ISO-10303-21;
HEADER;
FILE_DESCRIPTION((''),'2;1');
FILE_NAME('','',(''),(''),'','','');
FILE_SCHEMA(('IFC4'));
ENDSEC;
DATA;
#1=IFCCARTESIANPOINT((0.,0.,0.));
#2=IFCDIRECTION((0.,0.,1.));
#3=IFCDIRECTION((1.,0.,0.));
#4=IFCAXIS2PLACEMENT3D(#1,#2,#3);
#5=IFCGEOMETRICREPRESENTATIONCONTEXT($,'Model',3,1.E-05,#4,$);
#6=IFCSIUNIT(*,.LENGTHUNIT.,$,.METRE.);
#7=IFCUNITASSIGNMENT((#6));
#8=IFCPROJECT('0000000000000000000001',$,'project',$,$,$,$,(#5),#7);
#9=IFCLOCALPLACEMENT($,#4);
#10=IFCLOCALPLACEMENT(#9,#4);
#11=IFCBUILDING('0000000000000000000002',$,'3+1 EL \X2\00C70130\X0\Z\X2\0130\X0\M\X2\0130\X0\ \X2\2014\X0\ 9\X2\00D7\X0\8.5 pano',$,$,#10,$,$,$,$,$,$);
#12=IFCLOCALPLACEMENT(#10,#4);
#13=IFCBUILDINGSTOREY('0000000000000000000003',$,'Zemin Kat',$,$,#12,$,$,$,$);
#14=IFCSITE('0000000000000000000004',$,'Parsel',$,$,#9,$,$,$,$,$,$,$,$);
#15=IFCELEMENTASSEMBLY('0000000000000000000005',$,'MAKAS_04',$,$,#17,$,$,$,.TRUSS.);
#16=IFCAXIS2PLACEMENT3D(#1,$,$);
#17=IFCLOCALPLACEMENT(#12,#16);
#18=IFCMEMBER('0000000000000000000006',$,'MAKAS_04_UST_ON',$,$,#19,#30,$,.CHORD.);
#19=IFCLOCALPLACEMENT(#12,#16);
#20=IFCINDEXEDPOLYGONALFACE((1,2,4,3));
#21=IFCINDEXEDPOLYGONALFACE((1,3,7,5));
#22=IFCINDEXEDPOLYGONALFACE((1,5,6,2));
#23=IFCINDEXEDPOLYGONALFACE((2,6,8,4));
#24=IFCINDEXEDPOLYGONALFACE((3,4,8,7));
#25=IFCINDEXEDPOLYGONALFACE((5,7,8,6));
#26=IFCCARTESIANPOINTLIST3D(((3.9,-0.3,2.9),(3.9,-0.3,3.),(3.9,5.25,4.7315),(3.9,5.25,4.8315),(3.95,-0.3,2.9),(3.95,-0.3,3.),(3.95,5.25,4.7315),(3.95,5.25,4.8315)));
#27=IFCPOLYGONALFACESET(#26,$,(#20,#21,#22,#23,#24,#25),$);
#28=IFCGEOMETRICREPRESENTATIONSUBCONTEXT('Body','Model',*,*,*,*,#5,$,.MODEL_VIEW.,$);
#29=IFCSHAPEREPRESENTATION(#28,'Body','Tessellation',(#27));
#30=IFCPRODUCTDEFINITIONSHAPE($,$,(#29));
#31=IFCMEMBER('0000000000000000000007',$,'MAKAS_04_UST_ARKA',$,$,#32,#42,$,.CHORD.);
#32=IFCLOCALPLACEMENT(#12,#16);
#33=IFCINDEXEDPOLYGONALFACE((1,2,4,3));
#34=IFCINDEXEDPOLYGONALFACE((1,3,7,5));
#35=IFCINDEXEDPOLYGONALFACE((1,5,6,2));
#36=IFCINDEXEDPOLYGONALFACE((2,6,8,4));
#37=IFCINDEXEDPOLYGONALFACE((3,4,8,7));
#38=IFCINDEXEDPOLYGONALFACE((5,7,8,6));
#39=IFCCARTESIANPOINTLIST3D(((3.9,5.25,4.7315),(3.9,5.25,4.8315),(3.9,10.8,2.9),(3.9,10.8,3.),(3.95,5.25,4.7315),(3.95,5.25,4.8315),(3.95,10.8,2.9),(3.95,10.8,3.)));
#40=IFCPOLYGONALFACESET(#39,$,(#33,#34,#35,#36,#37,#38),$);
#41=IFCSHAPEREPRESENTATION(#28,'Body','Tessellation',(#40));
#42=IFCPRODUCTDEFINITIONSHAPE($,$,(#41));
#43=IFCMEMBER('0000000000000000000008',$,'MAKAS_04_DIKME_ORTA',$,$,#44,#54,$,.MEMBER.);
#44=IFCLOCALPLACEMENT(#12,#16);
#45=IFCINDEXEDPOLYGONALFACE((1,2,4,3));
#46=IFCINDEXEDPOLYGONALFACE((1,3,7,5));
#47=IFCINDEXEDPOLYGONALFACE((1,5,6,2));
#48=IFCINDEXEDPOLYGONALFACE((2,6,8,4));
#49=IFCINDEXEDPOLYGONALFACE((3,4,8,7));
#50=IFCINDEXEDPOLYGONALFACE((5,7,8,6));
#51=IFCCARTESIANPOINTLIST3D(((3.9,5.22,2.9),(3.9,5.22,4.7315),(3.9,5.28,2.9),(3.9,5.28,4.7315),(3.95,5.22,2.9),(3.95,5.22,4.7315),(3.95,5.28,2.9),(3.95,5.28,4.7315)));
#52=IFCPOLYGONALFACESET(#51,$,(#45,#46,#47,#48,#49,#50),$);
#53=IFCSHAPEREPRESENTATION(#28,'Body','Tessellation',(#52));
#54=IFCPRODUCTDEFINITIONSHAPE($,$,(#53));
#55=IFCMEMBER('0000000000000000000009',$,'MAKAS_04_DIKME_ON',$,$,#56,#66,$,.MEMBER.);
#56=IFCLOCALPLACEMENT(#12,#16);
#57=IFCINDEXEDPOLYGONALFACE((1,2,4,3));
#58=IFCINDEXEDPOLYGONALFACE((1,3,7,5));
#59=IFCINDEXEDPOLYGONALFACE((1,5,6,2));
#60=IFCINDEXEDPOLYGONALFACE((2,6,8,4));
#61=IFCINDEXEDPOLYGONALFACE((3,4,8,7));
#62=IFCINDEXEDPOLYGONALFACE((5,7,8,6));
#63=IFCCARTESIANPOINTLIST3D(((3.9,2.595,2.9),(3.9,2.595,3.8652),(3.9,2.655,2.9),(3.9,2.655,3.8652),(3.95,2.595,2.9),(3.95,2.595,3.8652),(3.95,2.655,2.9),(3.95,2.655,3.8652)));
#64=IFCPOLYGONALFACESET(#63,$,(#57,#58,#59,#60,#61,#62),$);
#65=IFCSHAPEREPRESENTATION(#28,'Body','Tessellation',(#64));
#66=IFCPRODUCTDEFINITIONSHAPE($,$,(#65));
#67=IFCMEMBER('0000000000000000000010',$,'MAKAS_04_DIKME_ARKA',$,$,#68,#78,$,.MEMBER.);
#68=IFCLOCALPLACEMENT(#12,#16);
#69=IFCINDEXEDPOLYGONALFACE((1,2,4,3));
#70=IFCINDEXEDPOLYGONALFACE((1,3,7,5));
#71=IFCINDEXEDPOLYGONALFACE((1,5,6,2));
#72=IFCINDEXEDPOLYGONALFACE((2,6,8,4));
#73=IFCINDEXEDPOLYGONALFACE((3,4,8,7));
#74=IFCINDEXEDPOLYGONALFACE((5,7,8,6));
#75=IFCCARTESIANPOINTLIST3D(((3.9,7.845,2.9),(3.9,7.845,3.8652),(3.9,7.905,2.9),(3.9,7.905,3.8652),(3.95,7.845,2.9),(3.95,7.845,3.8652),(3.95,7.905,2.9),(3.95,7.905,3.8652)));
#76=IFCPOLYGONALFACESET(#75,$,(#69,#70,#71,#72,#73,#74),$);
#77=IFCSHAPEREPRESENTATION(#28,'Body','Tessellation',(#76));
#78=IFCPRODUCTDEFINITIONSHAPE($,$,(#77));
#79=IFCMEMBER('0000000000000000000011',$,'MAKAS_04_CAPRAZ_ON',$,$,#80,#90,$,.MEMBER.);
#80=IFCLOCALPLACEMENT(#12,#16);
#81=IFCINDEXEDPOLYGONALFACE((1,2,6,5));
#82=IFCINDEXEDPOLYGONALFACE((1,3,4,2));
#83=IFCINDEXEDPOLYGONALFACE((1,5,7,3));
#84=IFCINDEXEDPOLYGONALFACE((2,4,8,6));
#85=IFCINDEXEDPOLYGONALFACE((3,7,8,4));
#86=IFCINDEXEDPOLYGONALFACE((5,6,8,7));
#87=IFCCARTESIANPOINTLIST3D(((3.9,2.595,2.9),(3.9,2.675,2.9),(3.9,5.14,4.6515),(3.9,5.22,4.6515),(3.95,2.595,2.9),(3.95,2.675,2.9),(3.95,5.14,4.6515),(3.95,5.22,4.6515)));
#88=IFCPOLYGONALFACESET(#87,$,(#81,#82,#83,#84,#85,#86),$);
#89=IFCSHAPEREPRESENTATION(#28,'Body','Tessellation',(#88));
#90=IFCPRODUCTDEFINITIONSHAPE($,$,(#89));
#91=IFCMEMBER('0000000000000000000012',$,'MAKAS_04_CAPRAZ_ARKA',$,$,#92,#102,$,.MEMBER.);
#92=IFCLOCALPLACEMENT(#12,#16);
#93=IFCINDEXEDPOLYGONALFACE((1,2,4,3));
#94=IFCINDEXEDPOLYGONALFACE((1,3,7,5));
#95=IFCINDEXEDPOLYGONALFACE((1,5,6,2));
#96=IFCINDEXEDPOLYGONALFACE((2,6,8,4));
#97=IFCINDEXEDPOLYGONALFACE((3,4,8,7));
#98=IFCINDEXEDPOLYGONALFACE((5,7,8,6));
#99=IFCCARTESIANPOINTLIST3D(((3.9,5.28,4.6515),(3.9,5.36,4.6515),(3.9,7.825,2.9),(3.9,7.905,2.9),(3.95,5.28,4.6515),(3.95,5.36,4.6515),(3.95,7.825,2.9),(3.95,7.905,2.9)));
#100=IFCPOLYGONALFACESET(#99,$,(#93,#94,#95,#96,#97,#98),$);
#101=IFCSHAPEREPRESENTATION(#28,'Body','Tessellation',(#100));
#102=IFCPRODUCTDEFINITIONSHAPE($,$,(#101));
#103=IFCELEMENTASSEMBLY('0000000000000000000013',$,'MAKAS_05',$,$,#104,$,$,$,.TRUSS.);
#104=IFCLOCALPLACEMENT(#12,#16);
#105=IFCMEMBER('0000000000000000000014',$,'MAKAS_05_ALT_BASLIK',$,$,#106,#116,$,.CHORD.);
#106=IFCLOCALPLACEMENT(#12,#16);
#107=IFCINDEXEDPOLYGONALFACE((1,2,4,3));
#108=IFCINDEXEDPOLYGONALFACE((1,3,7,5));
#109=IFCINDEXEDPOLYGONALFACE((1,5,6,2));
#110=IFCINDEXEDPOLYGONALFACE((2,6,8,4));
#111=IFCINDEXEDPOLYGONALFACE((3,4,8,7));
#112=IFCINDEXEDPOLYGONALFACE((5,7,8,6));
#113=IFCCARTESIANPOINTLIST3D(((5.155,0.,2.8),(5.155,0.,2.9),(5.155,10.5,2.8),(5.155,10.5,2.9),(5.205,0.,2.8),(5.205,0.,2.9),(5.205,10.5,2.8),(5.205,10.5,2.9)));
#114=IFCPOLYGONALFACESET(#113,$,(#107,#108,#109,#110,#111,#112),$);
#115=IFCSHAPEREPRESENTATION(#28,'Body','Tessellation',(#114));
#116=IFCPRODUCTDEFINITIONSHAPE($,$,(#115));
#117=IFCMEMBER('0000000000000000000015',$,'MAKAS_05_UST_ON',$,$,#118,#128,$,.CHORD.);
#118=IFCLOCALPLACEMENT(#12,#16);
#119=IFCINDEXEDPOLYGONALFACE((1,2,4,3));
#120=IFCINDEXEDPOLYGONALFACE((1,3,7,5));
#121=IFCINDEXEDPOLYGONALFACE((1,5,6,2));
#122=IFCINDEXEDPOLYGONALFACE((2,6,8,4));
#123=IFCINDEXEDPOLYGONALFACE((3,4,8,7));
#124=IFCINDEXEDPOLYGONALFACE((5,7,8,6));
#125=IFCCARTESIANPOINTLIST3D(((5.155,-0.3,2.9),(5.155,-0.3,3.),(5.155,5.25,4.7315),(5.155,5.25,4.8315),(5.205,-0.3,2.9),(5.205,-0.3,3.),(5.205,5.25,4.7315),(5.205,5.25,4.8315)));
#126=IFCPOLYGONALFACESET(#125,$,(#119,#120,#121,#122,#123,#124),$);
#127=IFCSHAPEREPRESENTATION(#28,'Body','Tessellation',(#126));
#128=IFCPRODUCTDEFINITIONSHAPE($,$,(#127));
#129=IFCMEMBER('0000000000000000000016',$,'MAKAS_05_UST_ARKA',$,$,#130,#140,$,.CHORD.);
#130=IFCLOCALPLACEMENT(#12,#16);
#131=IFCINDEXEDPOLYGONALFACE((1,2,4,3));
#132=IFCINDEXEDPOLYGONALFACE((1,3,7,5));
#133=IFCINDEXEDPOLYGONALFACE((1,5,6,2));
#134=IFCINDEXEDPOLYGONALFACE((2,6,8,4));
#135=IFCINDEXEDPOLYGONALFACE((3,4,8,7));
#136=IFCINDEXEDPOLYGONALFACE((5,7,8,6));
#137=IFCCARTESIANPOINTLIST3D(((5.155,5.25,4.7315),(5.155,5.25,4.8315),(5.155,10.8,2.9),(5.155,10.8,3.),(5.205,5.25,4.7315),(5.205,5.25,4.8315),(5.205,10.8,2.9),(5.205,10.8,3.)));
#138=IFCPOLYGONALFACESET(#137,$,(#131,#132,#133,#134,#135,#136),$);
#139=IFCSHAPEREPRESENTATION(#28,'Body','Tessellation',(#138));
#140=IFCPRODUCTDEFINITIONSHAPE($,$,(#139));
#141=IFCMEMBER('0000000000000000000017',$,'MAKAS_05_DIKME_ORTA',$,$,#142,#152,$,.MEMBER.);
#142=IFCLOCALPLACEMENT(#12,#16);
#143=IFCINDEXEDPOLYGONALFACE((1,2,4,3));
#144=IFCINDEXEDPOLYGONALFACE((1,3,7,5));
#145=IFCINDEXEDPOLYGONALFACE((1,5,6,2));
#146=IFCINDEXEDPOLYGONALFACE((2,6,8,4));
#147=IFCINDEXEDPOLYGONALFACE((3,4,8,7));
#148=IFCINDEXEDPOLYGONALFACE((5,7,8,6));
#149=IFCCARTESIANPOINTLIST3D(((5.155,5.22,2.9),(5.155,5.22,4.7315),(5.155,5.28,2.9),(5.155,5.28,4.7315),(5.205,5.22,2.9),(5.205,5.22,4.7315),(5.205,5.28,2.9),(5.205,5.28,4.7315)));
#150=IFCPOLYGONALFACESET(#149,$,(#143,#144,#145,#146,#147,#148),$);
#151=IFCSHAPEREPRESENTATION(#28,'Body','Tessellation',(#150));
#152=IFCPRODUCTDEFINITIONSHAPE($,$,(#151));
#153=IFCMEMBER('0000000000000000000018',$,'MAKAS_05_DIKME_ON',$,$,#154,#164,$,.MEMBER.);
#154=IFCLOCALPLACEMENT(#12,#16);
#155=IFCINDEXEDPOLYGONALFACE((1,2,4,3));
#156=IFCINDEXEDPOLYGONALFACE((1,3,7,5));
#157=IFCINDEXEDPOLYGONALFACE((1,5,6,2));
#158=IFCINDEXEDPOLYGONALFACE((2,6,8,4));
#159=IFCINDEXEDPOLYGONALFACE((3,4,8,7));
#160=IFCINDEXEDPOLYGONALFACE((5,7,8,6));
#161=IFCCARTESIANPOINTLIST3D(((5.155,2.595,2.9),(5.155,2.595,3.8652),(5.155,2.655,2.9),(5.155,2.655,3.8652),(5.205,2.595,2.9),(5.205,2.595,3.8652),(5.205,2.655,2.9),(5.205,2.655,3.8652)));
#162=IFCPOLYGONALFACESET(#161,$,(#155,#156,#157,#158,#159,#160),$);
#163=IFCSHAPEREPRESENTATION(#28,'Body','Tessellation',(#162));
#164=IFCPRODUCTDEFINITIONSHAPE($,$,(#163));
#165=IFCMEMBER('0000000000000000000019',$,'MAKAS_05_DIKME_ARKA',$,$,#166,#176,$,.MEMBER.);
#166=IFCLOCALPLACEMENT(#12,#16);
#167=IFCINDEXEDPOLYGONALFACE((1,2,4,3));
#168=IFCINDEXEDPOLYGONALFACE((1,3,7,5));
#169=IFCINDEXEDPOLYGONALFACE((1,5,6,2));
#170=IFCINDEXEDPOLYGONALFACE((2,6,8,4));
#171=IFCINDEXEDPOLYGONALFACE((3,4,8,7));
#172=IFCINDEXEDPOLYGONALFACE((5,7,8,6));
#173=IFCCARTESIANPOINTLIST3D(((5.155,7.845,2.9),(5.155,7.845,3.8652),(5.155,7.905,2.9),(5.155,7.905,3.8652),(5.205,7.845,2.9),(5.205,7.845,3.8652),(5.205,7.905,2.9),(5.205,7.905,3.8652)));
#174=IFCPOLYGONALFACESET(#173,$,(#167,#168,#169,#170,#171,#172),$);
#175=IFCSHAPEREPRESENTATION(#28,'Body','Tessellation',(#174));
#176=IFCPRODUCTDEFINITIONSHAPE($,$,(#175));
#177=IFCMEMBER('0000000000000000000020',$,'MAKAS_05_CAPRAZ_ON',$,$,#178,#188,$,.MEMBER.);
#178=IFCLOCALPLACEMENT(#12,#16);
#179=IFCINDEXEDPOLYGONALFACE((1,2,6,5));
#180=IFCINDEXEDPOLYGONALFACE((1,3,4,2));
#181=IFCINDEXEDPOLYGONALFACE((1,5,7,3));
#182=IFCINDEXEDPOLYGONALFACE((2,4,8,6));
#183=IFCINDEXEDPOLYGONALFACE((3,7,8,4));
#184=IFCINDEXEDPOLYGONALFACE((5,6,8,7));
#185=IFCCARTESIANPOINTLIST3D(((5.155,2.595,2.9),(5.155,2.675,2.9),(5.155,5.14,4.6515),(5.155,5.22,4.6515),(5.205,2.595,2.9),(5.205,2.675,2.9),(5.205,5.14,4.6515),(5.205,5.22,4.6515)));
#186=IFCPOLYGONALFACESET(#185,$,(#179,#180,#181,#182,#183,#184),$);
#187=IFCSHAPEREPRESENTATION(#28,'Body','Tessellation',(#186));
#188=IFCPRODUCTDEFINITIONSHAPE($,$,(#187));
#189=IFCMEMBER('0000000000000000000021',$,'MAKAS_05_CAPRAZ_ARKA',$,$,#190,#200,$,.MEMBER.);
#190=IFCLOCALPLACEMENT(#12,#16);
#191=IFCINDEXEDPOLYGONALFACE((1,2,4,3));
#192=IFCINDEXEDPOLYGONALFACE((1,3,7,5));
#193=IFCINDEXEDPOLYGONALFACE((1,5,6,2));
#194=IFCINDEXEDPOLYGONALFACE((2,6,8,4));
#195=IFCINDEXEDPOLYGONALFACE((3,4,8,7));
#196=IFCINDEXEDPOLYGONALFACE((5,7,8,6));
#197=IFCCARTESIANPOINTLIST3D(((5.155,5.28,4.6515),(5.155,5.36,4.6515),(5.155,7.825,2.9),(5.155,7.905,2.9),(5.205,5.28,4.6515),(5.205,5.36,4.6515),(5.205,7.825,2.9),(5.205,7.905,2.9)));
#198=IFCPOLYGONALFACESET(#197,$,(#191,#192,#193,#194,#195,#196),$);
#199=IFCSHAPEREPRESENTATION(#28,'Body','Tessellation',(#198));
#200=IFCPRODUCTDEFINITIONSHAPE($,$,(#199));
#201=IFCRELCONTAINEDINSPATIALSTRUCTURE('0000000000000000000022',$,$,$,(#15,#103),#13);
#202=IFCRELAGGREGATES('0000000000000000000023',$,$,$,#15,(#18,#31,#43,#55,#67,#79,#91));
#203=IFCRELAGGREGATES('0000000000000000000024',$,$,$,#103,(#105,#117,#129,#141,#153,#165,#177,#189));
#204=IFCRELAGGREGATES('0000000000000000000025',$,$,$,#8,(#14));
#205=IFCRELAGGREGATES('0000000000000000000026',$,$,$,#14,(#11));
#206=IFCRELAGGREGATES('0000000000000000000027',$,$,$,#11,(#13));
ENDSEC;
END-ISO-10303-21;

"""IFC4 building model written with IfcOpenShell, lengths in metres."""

from ifc_helpers import new_model, si_unit, frame, origin_with_axes, place, context, subcontext, project, spatial, line, indexed_curve, outline, extrude, element, aggregate, save


model = new_model("IFC4")

# Units and contexts
model_context = context("Model", 3, precision=1e-05, world=origin_with_axes())
body_context = subcontext(model_context, "Body", "Model", "MODEL_VIEW")
ifc_project = project(units=[si_unit("LENGTHUNIT", "METRE")], contexts=[model_context])

# Site, building, storey
site_placement = place(None, origin_with_axes())
site = spatial("IfcSite", under=ifc_project, at=site_placement, Name="Parsel")
building_placement = place(site_placement, origin_with_axes())
building = spatial("IfcBuilding", under=site, at=building_placement, Name="3+1 EL ÇİZİMİ — 9×8.5 pano")
storey_placement = place(building_placement, origin_with_axes())
storey = spatial("IfcBuildingStorey", under=building, at=storey_placement, Name="Zemin Kat")

# Element assemblies, members
assembly_1_placement = place(storey_placement, origin_with_axes())
assembly_1 = element("IfcElementAssembly", 1, at=assembly_1_placement, inside=storey, Name="MAKAS_04", PredefinedType="TRUSS")
member_1_placement = place(assembly_1_placement, origin_with_axes())
member_1 = element("IfcMember", 2, at=member_1_placement, Name="MAKAS_04_UST_ON", PredefinedType="CHORD", context=body_context, shape_type="SweptSolid", body=[
    extrude(outline(indexed_curve([(-0.3, 2.9), (5.25, 4.7315), (5.25, 4.8315), (-0.3, 3.0)], segments=[line(1, 2, 3, 4, 1)])), frame((3.9, 0.0, 0.0), z_axis=(1.0, 0.0, 0.0), x_axis=(0.0, 1.0, 0.0)), (0.0, 0.0, 1.0), 0.05),
])
member_2_placement = place(assembly_1_placement, origin_with_axes())
member_2 = element("IfcMember", 3, at=member_2_placement, Name="MAKAS_04_UST_ARKA", PredefinedType="CHORD", context=body_context, shape_type="SweptSolid", body=[
    extrude(outline(indexed_curve([(5.25, 4.7315), (10.8, 2.9), (10.8, 3.0), (5.25, 4.8315)], segments=[line(1, 2, 3, 4, 1)])), frame((3.9, 0.0, 0.0), z_axis=(1.0, 0.0, 0.0), x_axis=(0.0, 1.0, 0.0)), (0.0, 0.0, 1.0), 0.05),
])
member_3_placement = place(assembly_1_placement, origin_with_axes())
member_3 = element("IfcMember", 4, at=member_3_placement, Name="MAKAS_04_DIKME_ORTA", PredefinedType="MEMBER", context=body_context, shape_type="SweptSolid", body=[
    extrude(outline(indexed_curve([(5.22, 2.9), (5.28, 2.9), (5.28, 4.7315), (5.22, 4.7315)], segments=[line(1, 2, 3, 4, 1)])), frame((3.9, 0.0, 0.0), z_axis=(1.0, 0.0, 0.0), x_axis=(0.0, 1.0, 0.0)), (0.0, 0.0, 1.0), 0.05),
])
member_4_placement = place(assembly_1_placement, origin_with_axes())
member_4 = element("IfcMember", 5, at=member_4_placement, Name="MAKAS_04_DIKME_ON", PredefinedType="MEMBER", context=body_context, shape_type="SweptSolid", body=[
    extrude(outline(indexed_curve([(2.595, 2.9), (2.655, 2.9), (2.655, 3.8653), (2.595, 3.8653)], segments=[line(1, 2, 3, 4, 1)])), frame((3.9, 0.0, 0.0), z_axis=(1.0, 0.0, 0.0), x_axis=(0.0, 1.0, 0.0)), (0.0, 0.0, 1.0), 0.05),
])
member_5_placement = place(assembly_1_placement, origin_with_axes())
member_5 = element("IfcMember", 6, at=member_5_placement, Name="MAKAS_04_DIKME_ARKA", PredefinedType="MEMBER", context=body_context, shape_type="SweptSolid", body=[
    extrude(outline(indexed_curve([(7.845, 2.9), (7.905, 2.9), (7.905, 3.8653), (7.845, 3.8653)], segments=[line(1, 2, 3, 4, 1)])), frame((3.9, 0.0, 0.0), z_axis=(1.0, 0.0, 0.0), x_axis=(0.0, 1.0, 0.0)), (0.0, 0.0, 1.0), 0.05),
])
member_6_placement = place(assembly_1_placement, origin_with_axes())
member_6 = element("IfcMember", 7, at=member_6_placement, Name="MAKAS_04_CAPRAZ_ON", PredefinedType="MEMBER", context=body_context, shape_type="SweptSolid", body=[
    extrude(outline(indexed_curve([(2.595, 2.9), (2.675, 2.9), (5.22, 4.6515), (5.14, 4.6515)], segments=[line(1, 2, 3, 4, 1)])), frame((3.9, 0.0, 0.0), z_axis=(1.0, 0.0, 0.0), x_axis=(0.0, 1.0, 0.0)), (0.0, 0.0, 1.0), 0.05),
])
member_7_placement = place(assembly_1_placement, origin_with_axes())
member_7 = element("IfcMember", 8, at=member_7_placement, Name="MAKAS_04_CAPRAZ_ARKA", PredefinedType="MEMBER", context=body_context, shape_type="SweptSolid", body=[
    extrude(outline(indexed_curve([(7.825, 2.9), (7.905, 2.9), (5.36, 4.6515), (5.28, 4.6515)], segments=[line(1, 2, 3, 4, 1)])), frame((3.9, 0.0, 0.0), z_axis=(1.0, 0.0, 0.0), x_axis=(0.0, 1.0, 0.0)), (0.0, 0.0, 1.0), 0.05),
])
aggregate(assembly_1, [member_1, member_2, member_3, member_4, member_5, member_6, member_7])
assembly_2_placement = place(storey_placement, origin_with_axes())
assembly_2 = element("IfcElementAssembly", 9, at=assembly_2_placement, inside=storey, Name="MAKAS_05", PredefinedType="TRUSS")
member_8_placement = place(assembly_2_placement, origin_with_axes())
member_8 = element("IfcMember", 10, at=member_8_placement, Name="MAKAS_05_ALT_BASLIK", PredefinedType="CHORD", context=body_context, shape_type="SweptSolid", body=[
    extrude(outline(indexed_curve([(0.0, 2.8), (10.5, 2.8), (10.5, 2.9), (0.0, 2.9)], segments=[line(1, 2, 3, 4, 1)])), frame((5.155, 0.0, 0.0), z_axis=(1.0, 0.0, 0.0), x_axis=(0.0, 1.0, 0.0)), (0.0, 0.0, 1.0), 0.05),
])
member_9_placement = place(assembly_2_placement, origin_with_axes())
member_9 = element("IfcMember", 11, at=member_9_placement, Name="MAKAS_05_UST_ON", PredefinedType="CHORD", context=body_context, shape_type="SweptSolid", body=[
    extrude(outline(indexed_curve([(-0.3, 2.9), (5.25, 4.7315), (5.25, 4.8315), (-0.3, 3.0)], segments=[line(1, 2, 3, 4, 1)])), frame((5.155, 0.0, 0.0), z_axis=(1.0, 0.0, 0.0), x_axis=(0.0, 1.0, 0.0)), (0.0, 0.0, 1.0), 0.05),
])
member_10_placement = place(assembly_2_placement, origin_with_axes())
member_10 = element("IfcMember", 12, at=member_10_placement, Name="MAKAS_05_UST_ARKA", PredefinedType="CHORD", context=body_context, shape_type="SweptSolid", body=[
    extrude(outline(indexed_curve([(5.25, 4.7315), (10.8, 2.9), (10.8, 3.0), (5.25, 4.8315)], segments=[line(1, 2, 3, 4, 1)])), frame((5.155, 0.0, 0.0), z_axis=(1.0, 0.0, 0.0), x_axis=(0.0, 1.0, 0.0)), (0.0, 0.0, 1.0), 0.05),
])
member_11_placement = place(assembly_2_placement, origin_with_axes())
member_11 = element("IfcMember", 13, at=member_11_placement, Name="MAKAS_05_DIKME_ORTA", PredefinedType="MEMBER", context=body_context, shape_type="SweptSolid", body=[
    extrude(outline(indexed_curve([(5.22, 2.9), (5.28, 2.9), (5.28, 4.7315), (5.22, 4.7315)], segments=[line(1, 2, 3, 4, 1)])), frame((5.155, 0.0, 0.0), z_axis=(1.0, 0.0, 0.0), x_axis=(0.0, 1.0, 0.0)), (0.0, 0.0, 1.0), 0.05),
])
member_12_placement = place(assembly_2_placement, origin_with_axes())
member_12 = element("IfcMember", 14, at=member_12_placement, Name="MAKAS_05_DIKME_ON", PredefinedType="MEMBER", context=body_context, shape_type="SweptSolid", body=[
    extrude(outline(indexed_curve([(2.595, 2.9), (2.655, 2.9), (2.655, 3.8653), (2.595, 3.8653)], segments=[line(1, 2, 3, 4, 1)])), frame((5.155, 0.0, 0.0), z_axis=(1.0, 0.0, 0.0), x_axis=(0.0, 1.0, 0.0)), (0.0, 0.0, 1.0), 0.05),
])
member_13_placement = place(assembly_2_placement, origin_with_axes())
member_13 = element("IfcMember", 15, at=member_13_placement, Name="MAKAS_05_DIKME_ARKA", PredefinedType="MEMBER", context=body_context, shape_type="SweptSolid", body=[
    extrude(outline(indexed_curve([(7.845, 2.9), (7.905, 2.9), (7.905, 3.8653), (7.845, 3.8653)], segments=[line(1, 2, 3, 4, 1)])), frame((5.155, 0.0, 0.0), z_axis=(1.0, 0.0, 0.0), x_axis=(0.0, 1.0, 0.0)), (0.0, 0.0, 1.0), 0.05),
])
member_14_placement = place(assembly_2_placement, origin_with_axes())
member_14 = element("IfcMember", 16, at=member_14_placement, Name="MAKAS_05_CAPRAZ_ON", PredefinedType="MEMBER", context=body_context, shape_type="SweptSolid", body=[
    extrude(outline(indexed_curve([(2.595, 2.9), (2.675, 2.9), (5.22, 4.6515), (5.14, 4.6515)], segments=[line(1, 2, 3, 4, 1)])), frame((5.155, 0.0, 0.0), z_axis=(1.0, 0.0, 0.0), x_axis=(0.0, 1.0, 0.0)), (0.0, 0.0, 1.0), 0.05),
])
member_15_placement = place(assembly_2_placement, origin_with_axes())
member_15 = element("IfcMember", 17, at=member_15_placement, Name="MAKAS_05_CAPRAZ_ARKA", PredefinedType="MEMBER", context=body_context, shape_type="SweptSolid", body=[
    extrude(outline(indexed_curve([(7.825, 2.9), (7.905, 2.9), (5.36, 4.6515), (5.28, 4.6515)], segments=[line(1, 2, 3, 4, 1)])), frame((5.155, 0.0, 0.0), z_axis=(1.0, 0.0, 0.0), x_axis=(0.0, 1.0, 0.0)), (0.0, 0.0, 1.0), 0.05),
])
aggregate(assembly_2, [member_8, member_9, member_10, member_11, member_12, member_13, member_14, member_15])

save(model, "model.ifc")
